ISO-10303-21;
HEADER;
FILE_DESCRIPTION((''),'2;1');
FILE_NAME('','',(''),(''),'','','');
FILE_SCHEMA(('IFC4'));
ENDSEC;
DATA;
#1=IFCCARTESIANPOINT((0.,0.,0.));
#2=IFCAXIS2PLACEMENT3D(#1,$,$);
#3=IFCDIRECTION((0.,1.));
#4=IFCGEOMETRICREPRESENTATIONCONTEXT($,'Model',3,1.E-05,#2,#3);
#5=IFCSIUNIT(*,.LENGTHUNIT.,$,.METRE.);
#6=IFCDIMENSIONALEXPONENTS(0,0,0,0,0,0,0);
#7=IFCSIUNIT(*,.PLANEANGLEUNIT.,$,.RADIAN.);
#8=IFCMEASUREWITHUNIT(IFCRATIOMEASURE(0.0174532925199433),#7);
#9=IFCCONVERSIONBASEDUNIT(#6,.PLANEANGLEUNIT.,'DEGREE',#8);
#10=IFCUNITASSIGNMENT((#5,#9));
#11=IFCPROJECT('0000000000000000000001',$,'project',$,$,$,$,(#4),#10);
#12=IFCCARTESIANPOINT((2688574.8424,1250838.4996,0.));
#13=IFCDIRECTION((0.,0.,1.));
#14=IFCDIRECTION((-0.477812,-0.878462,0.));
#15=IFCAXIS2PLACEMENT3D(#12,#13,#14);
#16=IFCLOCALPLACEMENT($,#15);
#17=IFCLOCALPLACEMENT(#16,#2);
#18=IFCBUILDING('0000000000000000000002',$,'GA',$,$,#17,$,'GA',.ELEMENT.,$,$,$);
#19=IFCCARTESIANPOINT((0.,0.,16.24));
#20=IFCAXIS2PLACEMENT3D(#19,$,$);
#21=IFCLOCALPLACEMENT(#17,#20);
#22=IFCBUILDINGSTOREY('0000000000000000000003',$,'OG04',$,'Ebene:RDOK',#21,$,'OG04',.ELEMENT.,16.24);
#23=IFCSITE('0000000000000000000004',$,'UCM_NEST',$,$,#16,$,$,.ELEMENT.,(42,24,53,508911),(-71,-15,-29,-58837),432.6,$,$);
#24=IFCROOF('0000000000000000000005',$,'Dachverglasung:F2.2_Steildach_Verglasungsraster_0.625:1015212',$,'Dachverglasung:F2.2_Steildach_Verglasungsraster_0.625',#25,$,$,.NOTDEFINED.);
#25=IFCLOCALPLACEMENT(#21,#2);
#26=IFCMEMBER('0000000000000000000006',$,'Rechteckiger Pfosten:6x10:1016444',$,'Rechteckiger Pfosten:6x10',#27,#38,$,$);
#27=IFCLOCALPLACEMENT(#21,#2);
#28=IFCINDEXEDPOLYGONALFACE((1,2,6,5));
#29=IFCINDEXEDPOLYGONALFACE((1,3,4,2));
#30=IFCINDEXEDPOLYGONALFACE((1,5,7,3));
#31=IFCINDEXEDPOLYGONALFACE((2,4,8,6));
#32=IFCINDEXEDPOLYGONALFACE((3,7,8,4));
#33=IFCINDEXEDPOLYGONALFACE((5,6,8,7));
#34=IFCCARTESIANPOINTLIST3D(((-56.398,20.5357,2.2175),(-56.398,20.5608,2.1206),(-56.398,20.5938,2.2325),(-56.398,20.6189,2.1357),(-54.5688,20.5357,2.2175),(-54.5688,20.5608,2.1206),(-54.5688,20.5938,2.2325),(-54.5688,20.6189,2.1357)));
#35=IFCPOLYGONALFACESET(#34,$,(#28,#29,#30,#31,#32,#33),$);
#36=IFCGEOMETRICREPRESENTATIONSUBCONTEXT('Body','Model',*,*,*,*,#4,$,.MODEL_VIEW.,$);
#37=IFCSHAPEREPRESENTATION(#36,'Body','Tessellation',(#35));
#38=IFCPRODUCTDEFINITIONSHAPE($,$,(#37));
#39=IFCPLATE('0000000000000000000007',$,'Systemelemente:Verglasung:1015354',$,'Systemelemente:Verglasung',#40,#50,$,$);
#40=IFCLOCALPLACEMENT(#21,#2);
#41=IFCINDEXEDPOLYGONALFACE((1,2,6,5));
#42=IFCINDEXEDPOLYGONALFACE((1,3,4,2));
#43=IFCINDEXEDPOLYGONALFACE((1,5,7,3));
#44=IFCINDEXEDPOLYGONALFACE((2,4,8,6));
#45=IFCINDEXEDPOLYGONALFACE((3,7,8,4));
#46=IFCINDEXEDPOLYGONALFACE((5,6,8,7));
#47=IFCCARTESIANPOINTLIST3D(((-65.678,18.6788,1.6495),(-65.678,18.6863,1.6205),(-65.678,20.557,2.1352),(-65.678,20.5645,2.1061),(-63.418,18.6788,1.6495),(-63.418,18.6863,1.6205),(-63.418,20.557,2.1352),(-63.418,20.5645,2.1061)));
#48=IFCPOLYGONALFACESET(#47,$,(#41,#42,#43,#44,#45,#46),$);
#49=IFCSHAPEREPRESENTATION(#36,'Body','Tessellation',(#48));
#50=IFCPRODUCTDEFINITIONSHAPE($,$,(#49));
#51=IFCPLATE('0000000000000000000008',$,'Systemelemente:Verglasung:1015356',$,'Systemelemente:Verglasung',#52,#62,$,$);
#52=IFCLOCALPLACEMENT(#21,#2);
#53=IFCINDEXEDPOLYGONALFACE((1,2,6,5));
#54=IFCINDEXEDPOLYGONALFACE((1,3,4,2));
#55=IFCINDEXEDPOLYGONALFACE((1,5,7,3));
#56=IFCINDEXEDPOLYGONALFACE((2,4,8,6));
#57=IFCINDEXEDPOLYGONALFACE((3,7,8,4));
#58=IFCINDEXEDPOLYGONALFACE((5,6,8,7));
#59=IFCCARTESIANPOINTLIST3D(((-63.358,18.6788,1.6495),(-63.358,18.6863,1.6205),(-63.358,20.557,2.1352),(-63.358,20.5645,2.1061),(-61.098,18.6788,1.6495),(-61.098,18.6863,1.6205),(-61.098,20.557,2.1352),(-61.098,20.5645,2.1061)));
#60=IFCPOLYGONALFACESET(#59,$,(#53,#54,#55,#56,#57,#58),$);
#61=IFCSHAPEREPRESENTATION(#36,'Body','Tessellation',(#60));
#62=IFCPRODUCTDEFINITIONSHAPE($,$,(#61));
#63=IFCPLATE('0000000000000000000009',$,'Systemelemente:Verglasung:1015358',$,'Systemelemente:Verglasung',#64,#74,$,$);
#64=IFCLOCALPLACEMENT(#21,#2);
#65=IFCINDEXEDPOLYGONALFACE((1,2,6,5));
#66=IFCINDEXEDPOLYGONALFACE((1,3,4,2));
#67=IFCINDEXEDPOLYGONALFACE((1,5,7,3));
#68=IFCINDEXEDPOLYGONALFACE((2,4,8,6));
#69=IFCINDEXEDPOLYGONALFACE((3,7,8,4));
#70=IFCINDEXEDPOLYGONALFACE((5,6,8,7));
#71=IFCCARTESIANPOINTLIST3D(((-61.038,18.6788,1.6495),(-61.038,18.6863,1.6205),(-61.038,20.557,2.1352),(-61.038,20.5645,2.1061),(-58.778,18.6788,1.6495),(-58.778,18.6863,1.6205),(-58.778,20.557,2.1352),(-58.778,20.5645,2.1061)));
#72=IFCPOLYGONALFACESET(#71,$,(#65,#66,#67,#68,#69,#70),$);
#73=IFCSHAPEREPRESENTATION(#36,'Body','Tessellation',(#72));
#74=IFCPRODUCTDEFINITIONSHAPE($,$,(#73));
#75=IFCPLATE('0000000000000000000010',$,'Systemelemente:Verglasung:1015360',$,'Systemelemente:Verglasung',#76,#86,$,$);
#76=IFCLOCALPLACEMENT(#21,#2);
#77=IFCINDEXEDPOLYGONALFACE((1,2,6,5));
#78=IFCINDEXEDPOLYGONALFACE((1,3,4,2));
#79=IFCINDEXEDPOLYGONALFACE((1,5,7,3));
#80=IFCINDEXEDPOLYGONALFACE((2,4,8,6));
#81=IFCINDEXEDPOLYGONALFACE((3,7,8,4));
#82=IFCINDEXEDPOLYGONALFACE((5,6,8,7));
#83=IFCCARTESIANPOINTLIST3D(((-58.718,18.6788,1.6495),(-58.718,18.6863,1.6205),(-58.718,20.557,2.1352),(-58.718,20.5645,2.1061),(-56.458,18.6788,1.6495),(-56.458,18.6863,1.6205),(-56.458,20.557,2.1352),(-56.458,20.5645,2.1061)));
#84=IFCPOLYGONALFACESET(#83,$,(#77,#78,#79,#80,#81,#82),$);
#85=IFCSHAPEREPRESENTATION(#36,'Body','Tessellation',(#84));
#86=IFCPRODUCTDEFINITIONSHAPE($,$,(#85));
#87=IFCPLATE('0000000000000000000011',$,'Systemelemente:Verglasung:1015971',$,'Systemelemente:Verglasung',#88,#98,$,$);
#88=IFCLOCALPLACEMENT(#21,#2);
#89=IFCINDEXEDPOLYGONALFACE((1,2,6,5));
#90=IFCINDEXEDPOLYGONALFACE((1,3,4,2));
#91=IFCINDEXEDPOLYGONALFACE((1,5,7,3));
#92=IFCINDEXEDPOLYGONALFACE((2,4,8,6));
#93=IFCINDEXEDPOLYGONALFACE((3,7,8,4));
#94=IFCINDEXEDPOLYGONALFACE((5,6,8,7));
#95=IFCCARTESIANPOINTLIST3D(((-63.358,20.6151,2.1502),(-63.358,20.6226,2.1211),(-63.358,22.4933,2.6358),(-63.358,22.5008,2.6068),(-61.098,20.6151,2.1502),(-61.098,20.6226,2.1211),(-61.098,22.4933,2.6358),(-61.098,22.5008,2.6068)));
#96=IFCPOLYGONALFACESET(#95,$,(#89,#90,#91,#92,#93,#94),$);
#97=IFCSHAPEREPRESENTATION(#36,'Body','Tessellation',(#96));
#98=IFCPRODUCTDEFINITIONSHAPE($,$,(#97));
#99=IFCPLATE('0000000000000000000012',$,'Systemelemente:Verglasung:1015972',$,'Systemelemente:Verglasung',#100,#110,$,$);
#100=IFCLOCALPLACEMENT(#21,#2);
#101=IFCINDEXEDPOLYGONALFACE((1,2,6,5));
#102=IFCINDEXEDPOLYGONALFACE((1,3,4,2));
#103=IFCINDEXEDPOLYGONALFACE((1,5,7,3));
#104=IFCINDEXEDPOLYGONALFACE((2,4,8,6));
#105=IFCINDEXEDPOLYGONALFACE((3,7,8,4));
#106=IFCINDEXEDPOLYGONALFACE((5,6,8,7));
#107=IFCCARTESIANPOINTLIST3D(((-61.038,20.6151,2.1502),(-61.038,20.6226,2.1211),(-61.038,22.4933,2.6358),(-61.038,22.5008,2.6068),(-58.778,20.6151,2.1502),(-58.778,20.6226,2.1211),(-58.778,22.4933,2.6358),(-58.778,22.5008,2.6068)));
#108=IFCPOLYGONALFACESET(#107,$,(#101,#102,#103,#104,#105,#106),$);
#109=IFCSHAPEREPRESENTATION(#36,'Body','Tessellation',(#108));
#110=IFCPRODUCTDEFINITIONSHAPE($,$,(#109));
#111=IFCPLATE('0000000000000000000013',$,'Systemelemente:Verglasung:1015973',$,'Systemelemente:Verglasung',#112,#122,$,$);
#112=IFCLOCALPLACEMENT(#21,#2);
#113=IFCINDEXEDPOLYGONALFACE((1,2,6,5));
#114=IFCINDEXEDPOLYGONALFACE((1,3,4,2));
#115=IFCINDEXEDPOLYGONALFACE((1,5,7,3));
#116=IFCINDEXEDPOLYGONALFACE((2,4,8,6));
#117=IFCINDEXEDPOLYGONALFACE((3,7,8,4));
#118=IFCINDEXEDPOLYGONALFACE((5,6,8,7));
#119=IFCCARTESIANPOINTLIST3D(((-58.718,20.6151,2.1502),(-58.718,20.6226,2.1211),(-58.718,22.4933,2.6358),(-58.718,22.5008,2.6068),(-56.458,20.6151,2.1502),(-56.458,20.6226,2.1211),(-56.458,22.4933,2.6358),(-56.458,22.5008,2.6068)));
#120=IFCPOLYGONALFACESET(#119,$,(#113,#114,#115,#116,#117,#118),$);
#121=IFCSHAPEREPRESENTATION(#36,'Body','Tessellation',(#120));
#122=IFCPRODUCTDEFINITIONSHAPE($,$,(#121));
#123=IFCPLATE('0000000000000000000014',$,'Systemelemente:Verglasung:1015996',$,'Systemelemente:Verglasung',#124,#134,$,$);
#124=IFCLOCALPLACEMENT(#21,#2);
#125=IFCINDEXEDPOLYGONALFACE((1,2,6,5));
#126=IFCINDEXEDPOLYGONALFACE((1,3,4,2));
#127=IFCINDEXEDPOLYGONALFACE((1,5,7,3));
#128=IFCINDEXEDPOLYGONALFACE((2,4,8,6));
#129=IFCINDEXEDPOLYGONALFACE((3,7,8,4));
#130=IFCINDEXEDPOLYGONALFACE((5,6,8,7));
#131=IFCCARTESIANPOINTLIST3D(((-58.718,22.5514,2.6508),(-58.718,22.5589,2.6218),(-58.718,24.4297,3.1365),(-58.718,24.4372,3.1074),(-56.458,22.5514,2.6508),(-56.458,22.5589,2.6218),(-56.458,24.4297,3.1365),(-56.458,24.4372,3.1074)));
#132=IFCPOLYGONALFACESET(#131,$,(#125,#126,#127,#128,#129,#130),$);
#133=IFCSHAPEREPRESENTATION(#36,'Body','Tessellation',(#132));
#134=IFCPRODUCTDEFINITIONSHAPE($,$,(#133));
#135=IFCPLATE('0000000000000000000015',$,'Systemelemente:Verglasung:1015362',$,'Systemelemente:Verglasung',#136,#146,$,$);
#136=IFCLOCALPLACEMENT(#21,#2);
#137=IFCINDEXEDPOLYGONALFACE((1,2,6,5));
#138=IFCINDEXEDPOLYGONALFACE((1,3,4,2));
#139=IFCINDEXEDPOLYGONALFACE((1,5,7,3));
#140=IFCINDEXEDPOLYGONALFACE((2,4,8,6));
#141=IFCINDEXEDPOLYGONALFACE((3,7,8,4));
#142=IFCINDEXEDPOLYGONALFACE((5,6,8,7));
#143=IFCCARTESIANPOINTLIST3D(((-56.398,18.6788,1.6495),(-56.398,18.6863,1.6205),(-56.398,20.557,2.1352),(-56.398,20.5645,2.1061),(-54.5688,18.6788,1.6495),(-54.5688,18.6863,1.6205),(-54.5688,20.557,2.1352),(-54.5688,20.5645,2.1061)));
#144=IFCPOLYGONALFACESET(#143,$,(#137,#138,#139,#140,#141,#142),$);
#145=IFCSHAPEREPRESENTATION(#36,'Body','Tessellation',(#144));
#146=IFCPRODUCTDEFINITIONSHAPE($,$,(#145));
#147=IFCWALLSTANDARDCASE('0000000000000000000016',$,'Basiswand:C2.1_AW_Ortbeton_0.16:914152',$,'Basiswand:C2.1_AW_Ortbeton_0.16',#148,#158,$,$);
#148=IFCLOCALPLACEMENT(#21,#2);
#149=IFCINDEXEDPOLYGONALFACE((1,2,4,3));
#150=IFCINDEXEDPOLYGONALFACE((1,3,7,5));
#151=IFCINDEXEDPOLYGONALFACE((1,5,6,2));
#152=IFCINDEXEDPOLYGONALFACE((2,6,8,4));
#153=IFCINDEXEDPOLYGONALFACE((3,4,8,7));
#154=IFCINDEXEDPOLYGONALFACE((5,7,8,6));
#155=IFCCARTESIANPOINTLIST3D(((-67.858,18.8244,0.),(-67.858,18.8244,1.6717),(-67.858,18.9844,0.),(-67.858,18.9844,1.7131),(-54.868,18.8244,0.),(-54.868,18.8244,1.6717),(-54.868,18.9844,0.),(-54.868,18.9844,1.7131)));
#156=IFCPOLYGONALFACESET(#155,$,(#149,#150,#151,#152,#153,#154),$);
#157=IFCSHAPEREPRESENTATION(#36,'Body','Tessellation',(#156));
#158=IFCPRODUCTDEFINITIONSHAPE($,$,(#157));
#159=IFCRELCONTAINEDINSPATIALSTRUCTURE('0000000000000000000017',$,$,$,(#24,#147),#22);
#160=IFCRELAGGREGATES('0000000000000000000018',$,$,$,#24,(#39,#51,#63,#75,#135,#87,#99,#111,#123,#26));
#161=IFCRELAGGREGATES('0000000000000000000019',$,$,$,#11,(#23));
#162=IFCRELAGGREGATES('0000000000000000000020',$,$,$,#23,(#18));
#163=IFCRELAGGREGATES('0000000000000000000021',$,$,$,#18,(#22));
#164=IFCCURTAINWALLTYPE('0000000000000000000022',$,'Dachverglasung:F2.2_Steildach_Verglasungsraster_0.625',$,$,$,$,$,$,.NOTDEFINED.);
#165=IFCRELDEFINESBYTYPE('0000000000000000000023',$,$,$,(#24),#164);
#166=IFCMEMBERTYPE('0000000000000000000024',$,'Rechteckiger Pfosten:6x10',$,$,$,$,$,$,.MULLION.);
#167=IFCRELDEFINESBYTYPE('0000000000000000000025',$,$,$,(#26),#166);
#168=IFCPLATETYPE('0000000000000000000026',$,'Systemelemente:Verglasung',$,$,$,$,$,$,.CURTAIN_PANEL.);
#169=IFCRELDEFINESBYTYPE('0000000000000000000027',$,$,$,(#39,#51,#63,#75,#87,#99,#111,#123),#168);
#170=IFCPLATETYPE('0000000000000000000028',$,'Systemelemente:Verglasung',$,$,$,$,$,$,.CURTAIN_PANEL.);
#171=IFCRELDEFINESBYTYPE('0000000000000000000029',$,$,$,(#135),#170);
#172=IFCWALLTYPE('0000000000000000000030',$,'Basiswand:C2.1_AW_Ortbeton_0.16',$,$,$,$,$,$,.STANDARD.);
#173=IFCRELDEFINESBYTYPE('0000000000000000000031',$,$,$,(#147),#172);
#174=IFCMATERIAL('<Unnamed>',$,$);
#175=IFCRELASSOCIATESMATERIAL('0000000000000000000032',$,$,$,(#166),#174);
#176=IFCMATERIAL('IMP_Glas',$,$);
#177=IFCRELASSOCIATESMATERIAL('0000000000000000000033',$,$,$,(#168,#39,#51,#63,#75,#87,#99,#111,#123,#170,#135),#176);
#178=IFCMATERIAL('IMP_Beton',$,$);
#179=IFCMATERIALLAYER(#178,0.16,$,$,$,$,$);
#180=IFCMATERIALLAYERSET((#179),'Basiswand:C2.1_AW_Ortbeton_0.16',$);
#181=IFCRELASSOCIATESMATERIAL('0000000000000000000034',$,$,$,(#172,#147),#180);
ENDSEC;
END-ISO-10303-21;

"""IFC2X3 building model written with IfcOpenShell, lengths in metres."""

from ifc_helpers import new_model, entity, si_unit, converted_unit, direction, frame, frame_2d, origin, origin_2d_with_axis, place, context, subcontext, project, spatial, polyline, rectangle, extrude, clip, bounded_halfspace, source, transform, mapped, material, layer, layer_set, layer_usage, type_object, type_shapes, element, aggregate, save


model = new_model("IFC2X3")

# Units and contexts
model_context = context("Model", 3, precision=1e-05, world=origin(), true_north=direction((0.0, 1.0)))
body_context = subcontext(model_context, "Body", "Model", "MODEL_VIEW")
ifc_project = project(units=[si_unit("LENGTHUNIT", "METRE"), converted_unit("PLANEANGLEUNIT", "DEGREE", entity("IfcRatioMeasure", 0.0174532925199433), si_unit("PLANEANGLEUNIT", "RADIAN"), dimensions=[0, 0, 0, 0, 0, 0, 0])], contexts=[model_context])

# Site, building, storey
site_placement = place(None, frame((2688574.8424, 1250838.4996, 0.0), z_axis=(0.0, 0.0, 1.0), x_axis=(-0.477812, -0.878462, 0.0)))
site = spatial("IfcSite", under=ifc_project, at=site_placement, Name="UCM_NEST", CompositionType="ELEMENT", RefLatitude=(42, 24, 53, 508911), RefLongitude=(-71, -15, -29, -58837), RefElevation=432.6)
building_placement = place(site_placement, origin())
building = spatial("IfcBuilding", under=site, at=building_placement, Name="GA", LongName="GA", CompositionType="ELEMENT")
storey_placement = place(building_placement, frame((0.0, 0.0, 16.24)))
storey = spatial("IfcBuildingStorey", under=building, at=storey_placement, Name="OG04", ObjectType="Ebene:RDOK", LongName="OG04", CompositionType="ELEMENT", Elevation=16.24)

# Roof, member, plates
curtain_wall_type = type_object("IfcCurtainWallType", Name="Dachverglasung:F2.2_Steildach_Verglasungsraster_0.625", PredefinedType="NOTDEFINED")
roof_placement = place(storey_placement, frame((0.0, 0.0, -16.24)))
roof = element("IfcRoof", 1, at=roof_placement, inside=storey, type_object=curtain_wall_type, Name="Dachverglasung:F2.2_Steildach_Verglasungsraster_0.625:1015212", ObjectType="Dachverglasung:F2.2_Steildach_Verglasungsraster_0.625", ShapeType="NOTDEFINED")
ifc_material_1 = material(Name="<Unnamed>")
member_type_1 = type_object("IfcMemberType", Name="Rechteckiger Pfosten:6x10", PredefinedType="MULLION", material=ifc_material_1)
shared_shape_1 = source(origin(), body_context, "Body", "SweptSolid", [
    extrude(rectangle(XDim=0.1, YDim=0.06, at=origin_2d_with_axis()), frame((-0.03, -0.05, -1.8292), z_axis=(0.0, 0.0, 1.0), x_axis=(0.0, -1.0, 0.0)), (0.0, 0.0, 1.0), 1.8292),
])
type_shapes(member_type_1, [shared_shape_1])
member_1_placement = place(roof_placement, frame((-56.398, 20.6189, 18.3757), z_axis=(-1.0, 0.0, 0.0), x_axis=(0.0, 0.968163, 0.250322)))
member_1 = element("IfcMember", 2, at=member_1_placement, type_object=member_type_1, Name="Rechteckiger Pfosten:6x10:1016444", ObjectType="Rechteckiger Pfosten:6x10", context=body_context, shape_type="MappedRepresentation", body=[
    mapped(shared_shape_1, transform((0.0, 0.0, 0.0), scale=1.0)),
])
ifc_material_2 = material(Name="IMP_Glas")
plate_type_1 = type_object("IfcPlateType", Name="Systemelemente:Verglasung", PredefinedType="CURTAIN_PANEL", material=ifc_material_2)
shared_shape_2 = source(origin(), body_context, "Body", "SweptSolid", [
    extrude(rectangle(XDim=0.03, YDim=2.26, at=origin_2d_with_axis()), frame((0.0, 0.0, 0.0), z_axis=(0.0, 0.0, 1.0), x_axis=(0.0, 1.0, 0.0)), (0.0, 0.0, 1.0), 1.94),
])
type_shapes(plate_type_1, [shared_shape_2])
plate_1_placement = place(roof_placement, frame((-64.548, 18.6825, 17.875), z_axis=(0.0, 0.968163, 0.250322), x_axis=(1.0, 0.0, 0.0)))
plate_1 = element("IfcPlate", 3, at=plate_1_placement, type_object=plate_type_1, material=ifc_material_2, Name="Systemelemente:Verglasung:1015354", ObjectType="Systemelemente:Verglasung", context=body_context, shape_type="MappedRepresentation", body=[
    mapped(shared_shape_2, transform((0.0, 0.0, 0.0), scale=1.0)),
])
plate_2_placement = place(roof_placement, frame((-62.228, 18.6825, 17.875), z_axis=(0.0, 0.968163, 0.250322), x_axis=(1.0, 0.0, 0.0)))
plate_2 = element("IfcPlate", 4, at=plate_2_placement, type_object=plate_type_1, material=ifc_material_2, Name="Systemelemente:Verglasung:1015356", ObjectType="Systemelemente:Verglasung", context=body_context, shape_type="MappedRepresentation", body=[
    mapped(shared_shape_2, transform((0.0, 0.0, 0.0), scale=1.0)),
])
plate_3_placement = place(roof_placement, frame((-59.908, 18.6825, 17.875), z_axis=(0.0, 0.968163, 0.250322), x_axis=(1.0, 0.0, 0.0)))
plate_3 = element("IfcPlate", 5, at=plate_3_placement, type_object=plate_type_1, material=ifc_material_2, Name="Systemelemente:Verglasung:1015358", ObjectType="Systemelemente:Verglasung", context=body_context, shape_type="MappedRepresentation", body=[
    mapped(shared_shape_2, transform((0.0, 0.0, 0.0), scale=1.0)),
])
plate_4_placement = place(roof_placement, frame((-57.588, 18.6825, 17.875), z_axis=(0.0, 0.968163, 0.250322), x_axis=(1.0, 0.0, 0.0)))
plate_4 = element("IfcPlate", 6, at=plate_4_placement, type_object=plate_type_1, material=ifc_material_2, Name="Systemelemente:Verglasung:1015360", ObjectType="Systemelemente:Verglasung", context=body_context, shape_type="MappedRepresentation", body=[
    mapped(shared_shape_2, transform((0.0, 0.0, 0.0), scale=1.0)),
])
plate_5_placement = place(roof_placement, frame((-62.228, 20.6189, 18.3757), z_axis=(0.0, 0.968163, 0.250322), x_axis=(1.0, 0.0, 0.0)))
plate_5 = element("IfcPlate", 7, at=plate_5_placement, type_object=plate_type_1, material=ifc_material_2, Name="Systemelemente:Verglasung:1015971", ObjectType="Systemelemente:Verglasung", context=body_context, shape_type="MappedRepresentation", body=[
    mapped(shared_shape_2, transform((0.0, 0.0, 0.0), scale=1.0)),
])
plate_6_placement = place(roof_placement, frame((-59.908, 20.6189, 18.3757), z_axis=(0.0, 0.968163, 0.250322), x_axis=(1.0, 0.0, 0.0)))
plate_6 = element("IfcPlate", 8, at=plate_6_placement, type_object=plate_type_1, material=ifc_material_2, Name="Systemelemente:Verglasung:1015972", ObjectType="Systemelemente:Verglasung", context=body_context, shape_type="MappedRepresentation", body=[
    mapped(shared_shape_2, transform((0.0, 0.0, 0.0), scale=1.0)),
])
plate_7_placement = place(roof_placement, frame((-57.588, 20.6189, 18.3757), z_axis=(0.0, 0.968163, 0.250322), x_axis=(1.0, 0.0, 0.0)))
plate_7 = element("IfcPlate", 9, at=plate_7_placement, type_object=plate_type_1, material=ifc_material_2, Name="Systemelemente:Verglasung:1015973", ObjectType="Systemelemente:Verglasung", context=body_context, shape_type="MappedRepresentation", body=[
    mapped(shared_shape_2, transform((0.0, 0.0, 0.0), scale=1.0)),
])
plate_8_placement = place(roof_placement, frame((-57.588, 22.5552, 18.8763), z_axis=(0.0, 0.968163, 0.250322), x_axis=(1.0, 0.0, 0.0)))
plate_8 = element("IfcPlate", 10, at=plate_8_placement, type_object=plate_type_1, material=ifc_material_2, Name="Systemelemente:Verglasung:1015996", ObjectType="Systemelemente:Verglasung", context=body_context, shape_type="MappedRepresentation", body=[
    mapped(shared_shape_2, transform((0.0, 0.0, 0.0), scale=1.0)),
])
plate_type_2 = type_object("IfcPlateType", Name="Systemelemente:Verglasung", PredefinedType="CURTAIN_PANEL", material=ifc_material_2)
shared_shape_3 = source(origin(), body_context, "Body", "SweptSolid", [
    extrude(rectangle(XDim=0.03, YDim=1.8292, at=origin_2d_with_axis()), frame((0.0, 0.0, 0.0), z_axis=(0.0, 0.0, 1.0), x_axis=(0.0, 1.0, 0.0)), (0.0, 0.0, 1.0), 1.94),
])
type_shapes(plate_type_2, [shared_shape_3])
plate_9_placement = place(roof_placement, frame((-55.4834, 18.6825, 17.875), z_axis=(0.0, 0.968163, 0.250322), x_axis=(1.0, 0.0, 0.0)))
plate_9 = element("IfcPlate", 11, at=plate_9_placement, type_object=plate_type_2, material=ifc_material_2, Name="Systemelemente:Verglasung:1015362", ObjectType="Systemelemente:Verglasung", context=body_context, shape_type="MappedRepresentation", body=[
    mapped(shared_shape_3, transform((0.0, 0.0, 0.0), scale=1.0)),
])
aggregate(roof, [plate_1, plate_2, plate_3, plate_4, plate_9, plate_5, plate_6, plate_7, plate_8, member_1])

# Wall
ifc_material_3 = material(Name="IMP_Beton")
ifc_layer = layer(ifc_material_3, 0.16)
ifc_layer_set = layer_set([ifc_layer], Name="Basiswand:C2.1_AW_Ortbeton_0.16")
ifc_layer_usage = layer_usage(ifc_layer_set, "AXIS2", "NEGATIVE", 0.08)
wall_type = type_object("IfcWallType", Name="Basiswand:C2.1_AW_Ortbeton_0.16", PredefinedType="STANDARD", material=ifc_layer_set)
wall_placement = place(storey_placement, frame((-54.868, 18.9044, 0.0), z_axis=(0.0, 0.0, 1.0), x_axis=(-1.0, 0.0, 0.0)))
element("IfcWallStandardCase", 12, at=wall_placement, inside=storey, type_object=wall_type, material=ifc_layer_usage, Name="Basiswand:C2.1_AW_Ortbeton_0.16:914152", ObjectType="Basiswand:C2.1_AW_Ortbeton_0.16", context=body_context, shape_type="Clipping", body=[
    clip(extrude(rectangle(XDim=12.99, YDim=0.16, at=frame_2d((6.495, 0.0), x_axis=(-1.0, 0.0))), origin(), (0.0, 0.0, 1.0), 1.7131), bounded_halfspace(frame((0.0, -0.08, 1.7131), z_axis=(0.0, 0.250322, 0.968163), x_axis=(-1.0, 0.0, 0.0)), False, frame((0.0, -0.08, 1.7131)), polyline([(0.0, 0.0), (12.99, 0.0), (12.99, 0.16), (0.0, 0.16), (0.0, 0.0)]))),
])

save(model, "model.ifc")
